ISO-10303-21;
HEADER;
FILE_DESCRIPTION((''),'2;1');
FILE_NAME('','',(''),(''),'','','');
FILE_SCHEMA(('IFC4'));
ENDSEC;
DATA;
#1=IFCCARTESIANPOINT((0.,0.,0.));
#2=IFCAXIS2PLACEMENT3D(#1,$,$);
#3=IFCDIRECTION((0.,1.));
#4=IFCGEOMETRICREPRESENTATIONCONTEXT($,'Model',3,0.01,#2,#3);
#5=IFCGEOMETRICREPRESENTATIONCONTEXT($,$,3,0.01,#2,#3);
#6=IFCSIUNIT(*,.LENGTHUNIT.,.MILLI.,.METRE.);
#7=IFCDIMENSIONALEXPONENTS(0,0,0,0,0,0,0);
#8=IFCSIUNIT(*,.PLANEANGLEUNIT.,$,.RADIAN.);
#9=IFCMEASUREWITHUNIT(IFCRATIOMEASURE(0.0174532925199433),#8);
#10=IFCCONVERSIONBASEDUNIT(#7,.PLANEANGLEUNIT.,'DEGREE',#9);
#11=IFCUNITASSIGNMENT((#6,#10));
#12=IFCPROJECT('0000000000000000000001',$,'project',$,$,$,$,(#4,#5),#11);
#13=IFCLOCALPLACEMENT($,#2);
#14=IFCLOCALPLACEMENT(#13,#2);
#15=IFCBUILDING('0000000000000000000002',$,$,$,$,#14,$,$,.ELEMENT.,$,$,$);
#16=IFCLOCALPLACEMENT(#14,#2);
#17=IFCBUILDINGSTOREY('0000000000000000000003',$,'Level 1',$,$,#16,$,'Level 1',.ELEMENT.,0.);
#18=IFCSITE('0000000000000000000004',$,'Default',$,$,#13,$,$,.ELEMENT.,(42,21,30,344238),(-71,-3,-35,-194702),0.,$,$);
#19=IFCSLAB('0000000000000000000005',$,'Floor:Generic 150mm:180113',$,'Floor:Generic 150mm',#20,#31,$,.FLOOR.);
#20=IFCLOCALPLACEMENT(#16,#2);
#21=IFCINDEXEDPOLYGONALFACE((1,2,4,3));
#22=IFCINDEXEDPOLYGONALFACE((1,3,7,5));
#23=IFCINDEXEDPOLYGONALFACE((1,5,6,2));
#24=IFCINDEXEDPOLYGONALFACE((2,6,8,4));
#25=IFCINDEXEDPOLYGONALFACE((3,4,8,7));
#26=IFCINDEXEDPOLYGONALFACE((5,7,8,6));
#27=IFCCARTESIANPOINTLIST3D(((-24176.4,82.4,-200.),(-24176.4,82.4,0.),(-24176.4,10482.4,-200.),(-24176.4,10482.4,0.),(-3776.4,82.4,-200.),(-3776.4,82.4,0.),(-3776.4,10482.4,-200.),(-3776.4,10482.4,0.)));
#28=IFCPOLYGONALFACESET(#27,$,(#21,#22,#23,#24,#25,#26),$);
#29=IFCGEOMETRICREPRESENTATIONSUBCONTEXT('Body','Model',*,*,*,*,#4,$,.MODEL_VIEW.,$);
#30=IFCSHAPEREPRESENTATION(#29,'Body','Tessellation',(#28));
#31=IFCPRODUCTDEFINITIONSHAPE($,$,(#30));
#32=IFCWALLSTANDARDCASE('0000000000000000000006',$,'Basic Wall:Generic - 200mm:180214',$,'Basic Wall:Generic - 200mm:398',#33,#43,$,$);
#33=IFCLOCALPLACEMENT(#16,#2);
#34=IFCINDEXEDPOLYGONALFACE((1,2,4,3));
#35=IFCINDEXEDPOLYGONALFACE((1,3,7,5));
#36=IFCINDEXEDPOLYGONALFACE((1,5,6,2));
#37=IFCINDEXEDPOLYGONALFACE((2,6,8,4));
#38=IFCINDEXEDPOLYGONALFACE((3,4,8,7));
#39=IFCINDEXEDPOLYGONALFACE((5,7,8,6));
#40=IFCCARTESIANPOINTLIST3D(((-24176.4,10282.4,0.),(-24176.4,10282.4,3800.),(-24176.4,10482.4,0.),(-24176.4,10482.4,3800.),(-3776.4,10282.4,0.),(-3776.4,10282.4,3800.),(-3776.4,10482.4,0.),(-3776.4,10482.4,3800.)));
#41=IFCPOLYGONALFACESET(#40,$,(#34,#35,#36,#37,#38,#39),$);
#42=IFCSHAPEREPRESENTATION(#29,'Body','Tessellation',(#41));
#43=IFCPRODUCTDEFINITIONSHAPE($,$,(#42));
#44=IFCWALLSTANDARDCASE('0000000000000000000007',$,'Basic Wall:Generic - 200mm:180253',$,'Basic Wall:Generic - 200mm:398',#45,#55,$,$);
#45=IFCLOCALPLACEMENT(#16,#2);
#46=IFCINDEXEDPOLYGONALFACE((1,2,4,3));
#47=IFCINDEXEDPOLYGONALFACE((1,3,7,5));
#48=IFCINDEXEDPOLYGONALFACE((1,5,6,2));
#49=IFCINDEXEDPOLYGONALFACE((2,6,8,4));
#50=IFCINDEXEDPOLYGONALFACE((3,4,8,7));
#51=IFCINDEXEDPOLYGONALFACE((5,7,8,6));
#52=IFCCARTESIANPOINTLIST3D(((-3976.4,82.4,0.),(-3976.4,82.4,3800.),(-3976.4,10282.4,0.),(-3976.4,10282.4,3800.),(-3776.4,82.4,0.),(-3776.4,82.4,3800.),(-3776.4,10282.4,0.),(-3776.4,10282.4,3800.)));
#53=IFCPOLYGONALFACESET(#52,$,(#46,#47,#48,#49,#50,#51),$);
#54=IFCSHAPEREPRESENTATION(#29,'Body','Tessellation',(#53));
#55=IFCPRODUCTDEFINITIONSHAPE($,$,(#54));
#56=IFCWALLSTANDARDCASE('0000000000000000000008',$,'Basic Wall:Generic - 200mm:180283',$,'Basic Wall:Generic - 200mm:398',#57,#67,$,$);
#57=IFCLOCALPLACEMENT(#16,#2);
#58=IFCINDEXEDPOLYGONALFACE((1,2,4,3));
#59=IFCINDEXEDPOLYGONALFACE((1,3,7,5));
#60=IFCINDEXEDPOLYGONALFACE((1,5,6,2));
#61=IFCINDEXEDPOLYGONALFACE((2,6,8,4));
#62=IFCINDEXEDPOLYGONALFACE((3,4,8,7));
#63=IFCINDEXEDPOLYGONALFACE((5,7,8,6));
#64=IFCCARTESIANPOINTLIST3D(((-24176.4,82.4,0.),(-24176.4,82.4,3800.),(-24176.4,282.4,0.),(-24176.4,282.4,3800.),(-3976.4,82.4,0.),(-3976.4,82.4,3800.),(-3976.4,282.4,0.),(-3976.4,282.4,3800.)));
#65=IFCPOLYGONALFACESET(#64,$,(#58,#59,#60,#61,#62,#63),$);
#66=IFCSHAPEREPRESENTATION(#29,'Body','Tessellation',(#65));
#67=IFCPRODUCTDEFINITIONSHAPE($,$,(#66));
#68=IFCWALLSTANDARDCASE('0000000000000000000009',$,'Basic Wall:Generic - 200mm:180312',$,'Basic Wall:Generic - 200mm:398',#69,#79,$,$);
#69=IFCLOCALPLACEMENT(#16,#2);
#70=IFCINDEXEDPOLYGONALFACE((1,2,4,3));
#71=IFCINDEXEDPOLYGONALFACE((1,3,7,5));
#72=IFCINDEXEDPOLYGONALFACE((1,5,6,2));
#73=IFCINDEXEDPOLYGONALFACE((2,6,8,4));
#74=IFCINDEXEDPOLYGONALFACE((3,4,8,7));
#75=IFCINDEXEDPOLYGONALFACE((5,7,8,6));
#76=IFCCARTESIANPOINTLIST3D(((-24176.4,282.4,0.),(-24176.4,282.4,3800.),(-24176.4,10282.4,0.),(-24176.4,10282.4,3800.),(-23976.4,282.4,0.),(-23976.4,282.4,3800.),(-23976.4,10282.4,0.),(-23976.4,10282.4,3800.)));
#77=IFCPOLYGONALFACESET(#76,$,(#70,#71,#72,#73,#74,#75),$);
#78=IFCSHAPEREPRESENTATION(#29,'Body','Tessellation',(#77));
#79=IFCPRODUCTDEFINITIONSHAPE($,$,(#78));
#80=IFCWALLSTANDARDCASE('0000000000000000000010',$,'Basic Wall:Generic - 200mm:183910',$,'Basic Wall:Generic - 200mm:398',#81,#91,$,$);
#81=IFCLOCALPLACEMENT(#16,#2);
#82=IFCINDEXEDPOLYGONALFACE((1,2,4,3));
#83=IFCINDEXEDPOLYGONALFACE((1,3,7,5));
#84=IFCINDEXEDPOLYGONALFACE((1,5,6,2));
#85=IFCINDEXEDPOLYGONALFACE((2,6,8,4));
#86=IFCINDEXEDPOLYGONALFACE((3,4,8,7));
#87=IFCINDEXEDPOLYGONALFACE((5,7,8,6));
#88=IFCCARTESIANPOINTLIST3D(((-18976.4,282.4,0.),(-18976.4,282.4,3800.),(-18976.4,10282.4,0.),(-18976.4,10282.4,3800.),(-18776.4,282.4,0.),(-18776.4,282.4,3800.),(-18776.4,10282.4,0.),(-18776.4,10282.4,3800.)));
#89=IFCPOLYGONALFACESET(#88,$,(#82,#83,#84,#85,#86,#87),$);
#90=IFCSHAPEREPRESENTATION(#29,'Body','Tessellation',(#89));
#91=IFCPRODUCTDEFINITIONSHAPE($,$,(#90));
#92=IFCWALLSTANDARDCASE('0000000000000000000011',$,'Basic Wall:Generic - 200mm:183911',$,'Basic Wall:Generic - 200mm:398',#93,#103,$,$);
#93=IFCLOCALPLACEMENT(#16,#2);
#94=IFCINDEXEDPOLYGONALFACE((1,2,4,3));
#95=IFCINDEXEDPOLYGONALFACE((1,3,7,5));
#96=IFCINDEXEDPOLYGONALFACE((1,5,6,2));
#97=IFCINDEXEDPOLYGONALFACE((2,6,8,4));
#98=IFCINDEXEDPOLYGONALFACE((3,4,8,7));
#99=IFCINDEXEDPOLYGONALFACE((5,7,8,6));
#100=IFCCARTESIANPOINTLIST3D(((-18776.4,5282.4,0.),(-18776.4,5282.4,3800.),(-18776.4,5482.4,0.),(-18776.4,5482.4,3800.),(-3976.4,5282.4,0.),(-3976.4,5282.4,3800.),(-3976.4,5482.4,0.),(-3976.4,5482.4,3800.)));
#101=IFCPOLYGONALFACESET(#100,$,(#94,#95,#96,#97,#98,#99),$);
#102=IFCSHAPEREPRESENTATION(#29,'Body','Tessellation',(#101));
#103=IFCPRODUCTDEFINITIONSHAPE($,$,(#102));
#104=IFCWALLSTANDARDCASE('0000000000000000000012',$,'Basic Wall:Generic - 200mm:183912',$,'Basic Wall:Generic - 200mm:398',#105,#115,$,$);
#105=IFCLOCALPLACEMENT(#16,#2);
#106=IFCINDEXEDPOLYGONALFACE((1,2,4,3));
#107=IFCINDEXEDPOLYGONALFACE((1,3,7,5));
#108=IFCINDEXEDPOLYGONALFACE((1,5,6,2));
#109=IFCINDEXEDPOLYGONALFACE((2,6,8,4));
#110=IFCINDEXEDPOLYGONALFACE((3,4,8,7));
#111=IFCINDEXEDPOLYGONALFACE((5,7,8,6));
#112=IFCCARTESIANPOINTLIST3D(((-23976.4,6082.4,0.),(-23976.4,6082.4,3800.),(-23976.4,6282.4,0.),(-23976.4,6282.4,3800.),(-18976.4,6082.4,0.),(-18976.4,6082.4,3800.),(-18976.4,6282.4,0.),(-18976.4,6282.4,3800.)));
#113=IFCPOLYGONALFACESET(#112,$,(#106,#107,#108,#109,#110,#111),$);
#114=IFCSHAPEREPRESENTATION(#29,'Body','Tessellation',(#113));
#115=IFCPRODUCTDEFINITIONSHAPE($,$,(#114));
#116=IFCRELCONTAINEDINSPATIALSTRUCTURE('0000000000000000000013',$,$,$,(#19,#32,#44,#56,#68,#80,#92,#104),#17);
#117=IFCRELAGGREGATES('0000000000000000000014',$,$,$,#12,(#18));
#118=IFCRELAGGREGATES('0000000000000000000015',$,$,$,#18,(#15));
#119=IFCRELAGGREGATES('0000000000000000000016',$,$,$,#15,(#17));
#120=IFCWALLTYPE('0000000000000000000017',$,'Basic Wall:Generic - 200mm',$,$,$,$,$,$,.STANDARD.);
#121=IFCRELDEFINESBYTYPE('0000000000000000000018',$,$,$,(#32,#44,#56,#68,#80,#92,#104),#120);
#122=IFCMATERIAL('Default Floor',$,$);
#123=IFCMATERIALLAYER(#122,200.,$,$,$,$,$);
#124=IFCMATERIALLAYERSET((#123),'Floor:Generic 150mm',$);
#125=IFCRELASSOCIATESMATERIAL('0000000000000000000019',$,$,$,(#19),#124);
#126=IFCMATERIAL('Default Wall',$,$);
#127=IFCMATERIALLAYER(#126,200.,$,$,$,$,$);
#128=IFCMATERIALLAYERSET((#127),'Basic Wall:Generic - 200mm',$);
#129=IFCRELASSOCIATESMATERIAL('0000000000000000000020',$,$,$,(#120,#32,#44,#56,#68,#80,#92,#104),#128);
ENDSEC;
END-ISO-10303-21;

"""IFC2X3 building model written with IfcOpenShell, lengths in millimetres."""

from ifc_helpers import new_model, entity, si_unit, converted_unit, direction, frame, frame_2d, origin, origin_2d_with_axis, place, context, subcontext, project, spatial, rectangle, extrude, material, layer, layer_set, layer_usage, type_object, element, save


model = new_model("IFC2X3")

# Units and contexts
model_context = context("Model", 3, precision=0.01, world=origin(), true_north=direction((0.0, 1.0)))
context_of_model = context(None, 3, precision=0.01, world=origin(), true_north=direction((0.0, 1.0)))
body_context = subcontext(model_context, "Body", "Model", "MODEL_VIEW")
ifc_project = project(units=[si_unit("LENGTHUNIT", "METRE", prefix="MILLI"), converted_unit("PLANEANGLEUNIT", "DEGREE", entity("IfcRatioMeasure", 0.0174532925199433), si_unit("PLANEANGLEUNIT", "RADIAN"), dimensions=[0, 0, 0, 0, 0, 0, 0])], contexts=[model_context, context_of_model])

# Site, building, storey
site_placement = place(None, origin())
site = spatial("IfcSite", under=ifc_project, at=site_placement, Name="Default", CompositionType="ELEMENT", RefLatitude=(42, 21, 30, 344238), RefLongitude=(-71, -3, -35, -194702), RefElevation=0.0)
building_placement = place(site_placement, origin())
building = spatial("IfcBuilding", under=site, at=building_placement, CompositionType="ELEMENT")
storey_placement = place(building_placement, origin())
storey = spatial("IfcBuildingStorey", under=building, at=storey_placement, Name="Level 1", LongName="Level 1", CompositionType="ELEMENT", Elevation=0.0)

# Slab
ifc_material_1 = material(Name="Default Floor")
ifc_layer_1 = layer(ifc_material_1, 200.0)
ifc_layer_set_1 = layer_set([ifc_layer_1], Name="Floor:Generic 150mm")
ifc_layer_usage_1 = layer_usage(ifc_layer_set_1, "AXIS3", "POSITIVE", 0.0)
slab_placement = place(storey_placement, origin())
element("IfcSlab", 1, at=slab_placement, inside=storey, material=ifc_layer_usage_1, Name="Floor:Generic 150mm:180113", ObjectType="Floor:Generic 150mm", PredefinedType="FLOOR", context=body_context, shape_type="SweptSolid", body=[
    extrude(rectangle(XDim=10400.0, YDim=20400.0, at=origin_2d_with_axis()), frame((-13976.4, 5282.4, 0.0), z_axis=(0.0, 0.0, -1.0), x_axis=(0.0, 1.0, 0.0)), (0.0, 0.0, 1.0), 200.0),
])

# Walls
ifc_material_2 = material(Name="Default Wall")
ifc_layer_2 = layer(ifc_material_2, 200.0)
ifc_layer_set_2 = layer_set([ifc_layer_2], Name="Basic Wall:Generic - 200mm")
ifc_layer_usage_2 = layer_usage(ifc_layer_set_2, "AXIS2", "NEGATIVE", 100.0)
wall_type = type_object("IfcWallType", Name="Basic Wall:Generic - 200mm", PredefinedType="STANDARD", material=ifc_layer_set_2)
wall_1_placement = place(storey_placement, frame((-24176.4, 10382.4, 0.0)))
element("IfcWallStandardCase", 2, at=wall_1_placement, inside=storey, type_object=wall_type, material=ifc_layer_usage_2, Name="Basic Wall:Generic - 200mm:180214", ObjectType="Basic Wall:Generic - 200mm:398", context=body_context, shape_type="SweptSolid", body=[
    extrude(rectangle(XDim=20400.0, YDim=200.0, at=frame_2d((10200.0, 0.0), x_axis=(-1.0, 0.0))), origin(), (0.0, 0.0, 1.0), 3800.0),
])
ifc_layer_usage_3 = layer_usage(ifc_layer_set_2, "AXIS2", "NEGATIVE", 100.0)
wall_2_placement = place(storey_placement, frame((-3876.4, 10282.4, 0.0), z_axis=(0.0, 0.0, 1.0), x_axis=(0.0, -1.0, 0.0)))
element("IfcWallStandardCase", 3, at=wall_2_placement, inside=storey, type_object=wall_type, material=ifc_layer_usage_3, Name="Basic Wall:Generic - 200mm:180253", ObjectType="Basic Wall:Generic - 200mm:398", context=body_context, shape_type="SweptSolid", body=[
    extrude(rectangle(XDim=10200.0, YDim=200.0, at=frame_2d((5100.0, 0.0), x_axis=(-1.0, 0.0))), origin(), (0.0, 0.0, 1.0), 3800.0),
])
ifc_layer_usage_4 = layer_usage(ifc_layer_set_2, "AXIS2", "NEGATIVE", 100.0)
wall_3_placement = place(storey_placement, frame((-3976.4, 182.4, 0.0), z_axis=(0.0, 0.0, 1.0), x_axis=(-1.0, 0.0, 0.0)))
element("IfcWallStandardCase", 4, at=wall_3_placement, inside=storey, type_object=wall_type, material=ifc_layer_usage_4, Name="Basic Wall:Generic - 200mm:180283", ObjectType="Basic Wall:Generic - 200mm:398", context=body_context, shape_type="SweptSolid", body=[
    extrude(rectangle(XDim=20200.0, YDim=200.0, at=frame_2d((10100.0, 0.0), x_axis=(-1.0, 0.0))), origin(), (0.0, 0.0, 1.0), 3800.0),
])
ifc_layer_usage_5 = layer_usage(ifc_layer_set_2, "AXIS2", "NEGATIVE", 100.0)
wall_4_placement = place(storey_placement, frame((-24076.4, 282.4, 0.0), z_axis=(0.0, 0.0, 1.0), x_axis=(0.0, 1.0, 0.0)))
element("IfcWallStandardCase", 5, at=wall_4_placement, inside=storey, type_object=wall_type, material=ifc_layer_usage_5, Name="Basic Wall:Generic - 200mm:180312", ObjectType="Basic Wall:Generic - 200mm:398", context=body_context, shape_type="SweptSolid", body=[
    extrude(rectangle(XDim=10000.0, YDim=200.0, at=frame_2d((5000.0, 0.0), x_axis=(-1.0, 0.0))), origin(), (0.0, 0.0, 1.0), 3800.0),
])
ifc_layer_usage_6 = layer_usage(ifc_layer_set_2, "AXIS2", "NEGATIVE", 100.0)
wall_5_placement = place(storey_placement, frame((-18876.4, 10282.4, 0.0), z_axis=(0.0, 0.0, 1.0), x_axis=(0.0, -1.0, 0.0)))
element("IfcWallStandardCase", 6, at=wall_5_placement, inside=storey, type_object=wall_type, material=ifc_layer_usage_6, Name="Basic Wall:Generic - 200mm:183910", ObjectType="Basic Wall:Generic - 200mm:398", context=body_context, shape_type="SweptSolid", body=[
    extrude(rectangle(XDim=10000.0, YDim=200.0, at=frame_2d((5000.0, 0.0), x_axis=(-1.0, 0.0))), origin(), (0.0, 0.0, 1.0), 3800.0),
])
ifc_layer_usage_7 = layer_usage(ifc_layer_set_2, "AXIS2", "NEGATIVE", 100.0)
wall_6_placement = place(storey_placement, frame((-18776.4, 5382.4, 0.0)))
element("IfcWallStandardCase", 7, at=wall_6_placement, inside=storey, type_object=wall_type, material=ifc_layer_usage_7, Name="Basic Wall:Generic - 200mm:183911", ObjectType="Basic Wall:Generic - 200mm:398", context=body_context, shape_type="SweptSolid", body=[
    extrude(rectangle(XDim=14800.0, YDim=200.0, at=frame_2d((7400.0, 0.0), x_axis=(-1.0, 0.0))), origin(), (0.0, 0.0, 1.0), 3800.0),
])
ifc_layer_usage_8 = layer_usage(ifc_layer_set_2, "AXIS2", "NEGATIVE", 100.0)
wall_7_placement = place(storey_placement, frame((-23976.4, 6182.4, 0.0)))
element("IfcWallStandardCase", 8, at=wall_7_placement, inside=storey, type_object=wall_type, material=ifc_layer_usage_8, Name="Basic Wall:Generic - 200mm:183912", ObjectType="Basic Wall:Generic - 200mm:398", context=body_context, shape_type="SweptSolid", body=[
    extrude(rectangle(XDim=5000.0, YDim=200.0, at=frame_2d((2500.0, 0.0), x_axis=(-1.0, 0.0))), origin(), (0.0, 0.0, 1.0), 3800.0),
])

save(model, "model.ifc")
